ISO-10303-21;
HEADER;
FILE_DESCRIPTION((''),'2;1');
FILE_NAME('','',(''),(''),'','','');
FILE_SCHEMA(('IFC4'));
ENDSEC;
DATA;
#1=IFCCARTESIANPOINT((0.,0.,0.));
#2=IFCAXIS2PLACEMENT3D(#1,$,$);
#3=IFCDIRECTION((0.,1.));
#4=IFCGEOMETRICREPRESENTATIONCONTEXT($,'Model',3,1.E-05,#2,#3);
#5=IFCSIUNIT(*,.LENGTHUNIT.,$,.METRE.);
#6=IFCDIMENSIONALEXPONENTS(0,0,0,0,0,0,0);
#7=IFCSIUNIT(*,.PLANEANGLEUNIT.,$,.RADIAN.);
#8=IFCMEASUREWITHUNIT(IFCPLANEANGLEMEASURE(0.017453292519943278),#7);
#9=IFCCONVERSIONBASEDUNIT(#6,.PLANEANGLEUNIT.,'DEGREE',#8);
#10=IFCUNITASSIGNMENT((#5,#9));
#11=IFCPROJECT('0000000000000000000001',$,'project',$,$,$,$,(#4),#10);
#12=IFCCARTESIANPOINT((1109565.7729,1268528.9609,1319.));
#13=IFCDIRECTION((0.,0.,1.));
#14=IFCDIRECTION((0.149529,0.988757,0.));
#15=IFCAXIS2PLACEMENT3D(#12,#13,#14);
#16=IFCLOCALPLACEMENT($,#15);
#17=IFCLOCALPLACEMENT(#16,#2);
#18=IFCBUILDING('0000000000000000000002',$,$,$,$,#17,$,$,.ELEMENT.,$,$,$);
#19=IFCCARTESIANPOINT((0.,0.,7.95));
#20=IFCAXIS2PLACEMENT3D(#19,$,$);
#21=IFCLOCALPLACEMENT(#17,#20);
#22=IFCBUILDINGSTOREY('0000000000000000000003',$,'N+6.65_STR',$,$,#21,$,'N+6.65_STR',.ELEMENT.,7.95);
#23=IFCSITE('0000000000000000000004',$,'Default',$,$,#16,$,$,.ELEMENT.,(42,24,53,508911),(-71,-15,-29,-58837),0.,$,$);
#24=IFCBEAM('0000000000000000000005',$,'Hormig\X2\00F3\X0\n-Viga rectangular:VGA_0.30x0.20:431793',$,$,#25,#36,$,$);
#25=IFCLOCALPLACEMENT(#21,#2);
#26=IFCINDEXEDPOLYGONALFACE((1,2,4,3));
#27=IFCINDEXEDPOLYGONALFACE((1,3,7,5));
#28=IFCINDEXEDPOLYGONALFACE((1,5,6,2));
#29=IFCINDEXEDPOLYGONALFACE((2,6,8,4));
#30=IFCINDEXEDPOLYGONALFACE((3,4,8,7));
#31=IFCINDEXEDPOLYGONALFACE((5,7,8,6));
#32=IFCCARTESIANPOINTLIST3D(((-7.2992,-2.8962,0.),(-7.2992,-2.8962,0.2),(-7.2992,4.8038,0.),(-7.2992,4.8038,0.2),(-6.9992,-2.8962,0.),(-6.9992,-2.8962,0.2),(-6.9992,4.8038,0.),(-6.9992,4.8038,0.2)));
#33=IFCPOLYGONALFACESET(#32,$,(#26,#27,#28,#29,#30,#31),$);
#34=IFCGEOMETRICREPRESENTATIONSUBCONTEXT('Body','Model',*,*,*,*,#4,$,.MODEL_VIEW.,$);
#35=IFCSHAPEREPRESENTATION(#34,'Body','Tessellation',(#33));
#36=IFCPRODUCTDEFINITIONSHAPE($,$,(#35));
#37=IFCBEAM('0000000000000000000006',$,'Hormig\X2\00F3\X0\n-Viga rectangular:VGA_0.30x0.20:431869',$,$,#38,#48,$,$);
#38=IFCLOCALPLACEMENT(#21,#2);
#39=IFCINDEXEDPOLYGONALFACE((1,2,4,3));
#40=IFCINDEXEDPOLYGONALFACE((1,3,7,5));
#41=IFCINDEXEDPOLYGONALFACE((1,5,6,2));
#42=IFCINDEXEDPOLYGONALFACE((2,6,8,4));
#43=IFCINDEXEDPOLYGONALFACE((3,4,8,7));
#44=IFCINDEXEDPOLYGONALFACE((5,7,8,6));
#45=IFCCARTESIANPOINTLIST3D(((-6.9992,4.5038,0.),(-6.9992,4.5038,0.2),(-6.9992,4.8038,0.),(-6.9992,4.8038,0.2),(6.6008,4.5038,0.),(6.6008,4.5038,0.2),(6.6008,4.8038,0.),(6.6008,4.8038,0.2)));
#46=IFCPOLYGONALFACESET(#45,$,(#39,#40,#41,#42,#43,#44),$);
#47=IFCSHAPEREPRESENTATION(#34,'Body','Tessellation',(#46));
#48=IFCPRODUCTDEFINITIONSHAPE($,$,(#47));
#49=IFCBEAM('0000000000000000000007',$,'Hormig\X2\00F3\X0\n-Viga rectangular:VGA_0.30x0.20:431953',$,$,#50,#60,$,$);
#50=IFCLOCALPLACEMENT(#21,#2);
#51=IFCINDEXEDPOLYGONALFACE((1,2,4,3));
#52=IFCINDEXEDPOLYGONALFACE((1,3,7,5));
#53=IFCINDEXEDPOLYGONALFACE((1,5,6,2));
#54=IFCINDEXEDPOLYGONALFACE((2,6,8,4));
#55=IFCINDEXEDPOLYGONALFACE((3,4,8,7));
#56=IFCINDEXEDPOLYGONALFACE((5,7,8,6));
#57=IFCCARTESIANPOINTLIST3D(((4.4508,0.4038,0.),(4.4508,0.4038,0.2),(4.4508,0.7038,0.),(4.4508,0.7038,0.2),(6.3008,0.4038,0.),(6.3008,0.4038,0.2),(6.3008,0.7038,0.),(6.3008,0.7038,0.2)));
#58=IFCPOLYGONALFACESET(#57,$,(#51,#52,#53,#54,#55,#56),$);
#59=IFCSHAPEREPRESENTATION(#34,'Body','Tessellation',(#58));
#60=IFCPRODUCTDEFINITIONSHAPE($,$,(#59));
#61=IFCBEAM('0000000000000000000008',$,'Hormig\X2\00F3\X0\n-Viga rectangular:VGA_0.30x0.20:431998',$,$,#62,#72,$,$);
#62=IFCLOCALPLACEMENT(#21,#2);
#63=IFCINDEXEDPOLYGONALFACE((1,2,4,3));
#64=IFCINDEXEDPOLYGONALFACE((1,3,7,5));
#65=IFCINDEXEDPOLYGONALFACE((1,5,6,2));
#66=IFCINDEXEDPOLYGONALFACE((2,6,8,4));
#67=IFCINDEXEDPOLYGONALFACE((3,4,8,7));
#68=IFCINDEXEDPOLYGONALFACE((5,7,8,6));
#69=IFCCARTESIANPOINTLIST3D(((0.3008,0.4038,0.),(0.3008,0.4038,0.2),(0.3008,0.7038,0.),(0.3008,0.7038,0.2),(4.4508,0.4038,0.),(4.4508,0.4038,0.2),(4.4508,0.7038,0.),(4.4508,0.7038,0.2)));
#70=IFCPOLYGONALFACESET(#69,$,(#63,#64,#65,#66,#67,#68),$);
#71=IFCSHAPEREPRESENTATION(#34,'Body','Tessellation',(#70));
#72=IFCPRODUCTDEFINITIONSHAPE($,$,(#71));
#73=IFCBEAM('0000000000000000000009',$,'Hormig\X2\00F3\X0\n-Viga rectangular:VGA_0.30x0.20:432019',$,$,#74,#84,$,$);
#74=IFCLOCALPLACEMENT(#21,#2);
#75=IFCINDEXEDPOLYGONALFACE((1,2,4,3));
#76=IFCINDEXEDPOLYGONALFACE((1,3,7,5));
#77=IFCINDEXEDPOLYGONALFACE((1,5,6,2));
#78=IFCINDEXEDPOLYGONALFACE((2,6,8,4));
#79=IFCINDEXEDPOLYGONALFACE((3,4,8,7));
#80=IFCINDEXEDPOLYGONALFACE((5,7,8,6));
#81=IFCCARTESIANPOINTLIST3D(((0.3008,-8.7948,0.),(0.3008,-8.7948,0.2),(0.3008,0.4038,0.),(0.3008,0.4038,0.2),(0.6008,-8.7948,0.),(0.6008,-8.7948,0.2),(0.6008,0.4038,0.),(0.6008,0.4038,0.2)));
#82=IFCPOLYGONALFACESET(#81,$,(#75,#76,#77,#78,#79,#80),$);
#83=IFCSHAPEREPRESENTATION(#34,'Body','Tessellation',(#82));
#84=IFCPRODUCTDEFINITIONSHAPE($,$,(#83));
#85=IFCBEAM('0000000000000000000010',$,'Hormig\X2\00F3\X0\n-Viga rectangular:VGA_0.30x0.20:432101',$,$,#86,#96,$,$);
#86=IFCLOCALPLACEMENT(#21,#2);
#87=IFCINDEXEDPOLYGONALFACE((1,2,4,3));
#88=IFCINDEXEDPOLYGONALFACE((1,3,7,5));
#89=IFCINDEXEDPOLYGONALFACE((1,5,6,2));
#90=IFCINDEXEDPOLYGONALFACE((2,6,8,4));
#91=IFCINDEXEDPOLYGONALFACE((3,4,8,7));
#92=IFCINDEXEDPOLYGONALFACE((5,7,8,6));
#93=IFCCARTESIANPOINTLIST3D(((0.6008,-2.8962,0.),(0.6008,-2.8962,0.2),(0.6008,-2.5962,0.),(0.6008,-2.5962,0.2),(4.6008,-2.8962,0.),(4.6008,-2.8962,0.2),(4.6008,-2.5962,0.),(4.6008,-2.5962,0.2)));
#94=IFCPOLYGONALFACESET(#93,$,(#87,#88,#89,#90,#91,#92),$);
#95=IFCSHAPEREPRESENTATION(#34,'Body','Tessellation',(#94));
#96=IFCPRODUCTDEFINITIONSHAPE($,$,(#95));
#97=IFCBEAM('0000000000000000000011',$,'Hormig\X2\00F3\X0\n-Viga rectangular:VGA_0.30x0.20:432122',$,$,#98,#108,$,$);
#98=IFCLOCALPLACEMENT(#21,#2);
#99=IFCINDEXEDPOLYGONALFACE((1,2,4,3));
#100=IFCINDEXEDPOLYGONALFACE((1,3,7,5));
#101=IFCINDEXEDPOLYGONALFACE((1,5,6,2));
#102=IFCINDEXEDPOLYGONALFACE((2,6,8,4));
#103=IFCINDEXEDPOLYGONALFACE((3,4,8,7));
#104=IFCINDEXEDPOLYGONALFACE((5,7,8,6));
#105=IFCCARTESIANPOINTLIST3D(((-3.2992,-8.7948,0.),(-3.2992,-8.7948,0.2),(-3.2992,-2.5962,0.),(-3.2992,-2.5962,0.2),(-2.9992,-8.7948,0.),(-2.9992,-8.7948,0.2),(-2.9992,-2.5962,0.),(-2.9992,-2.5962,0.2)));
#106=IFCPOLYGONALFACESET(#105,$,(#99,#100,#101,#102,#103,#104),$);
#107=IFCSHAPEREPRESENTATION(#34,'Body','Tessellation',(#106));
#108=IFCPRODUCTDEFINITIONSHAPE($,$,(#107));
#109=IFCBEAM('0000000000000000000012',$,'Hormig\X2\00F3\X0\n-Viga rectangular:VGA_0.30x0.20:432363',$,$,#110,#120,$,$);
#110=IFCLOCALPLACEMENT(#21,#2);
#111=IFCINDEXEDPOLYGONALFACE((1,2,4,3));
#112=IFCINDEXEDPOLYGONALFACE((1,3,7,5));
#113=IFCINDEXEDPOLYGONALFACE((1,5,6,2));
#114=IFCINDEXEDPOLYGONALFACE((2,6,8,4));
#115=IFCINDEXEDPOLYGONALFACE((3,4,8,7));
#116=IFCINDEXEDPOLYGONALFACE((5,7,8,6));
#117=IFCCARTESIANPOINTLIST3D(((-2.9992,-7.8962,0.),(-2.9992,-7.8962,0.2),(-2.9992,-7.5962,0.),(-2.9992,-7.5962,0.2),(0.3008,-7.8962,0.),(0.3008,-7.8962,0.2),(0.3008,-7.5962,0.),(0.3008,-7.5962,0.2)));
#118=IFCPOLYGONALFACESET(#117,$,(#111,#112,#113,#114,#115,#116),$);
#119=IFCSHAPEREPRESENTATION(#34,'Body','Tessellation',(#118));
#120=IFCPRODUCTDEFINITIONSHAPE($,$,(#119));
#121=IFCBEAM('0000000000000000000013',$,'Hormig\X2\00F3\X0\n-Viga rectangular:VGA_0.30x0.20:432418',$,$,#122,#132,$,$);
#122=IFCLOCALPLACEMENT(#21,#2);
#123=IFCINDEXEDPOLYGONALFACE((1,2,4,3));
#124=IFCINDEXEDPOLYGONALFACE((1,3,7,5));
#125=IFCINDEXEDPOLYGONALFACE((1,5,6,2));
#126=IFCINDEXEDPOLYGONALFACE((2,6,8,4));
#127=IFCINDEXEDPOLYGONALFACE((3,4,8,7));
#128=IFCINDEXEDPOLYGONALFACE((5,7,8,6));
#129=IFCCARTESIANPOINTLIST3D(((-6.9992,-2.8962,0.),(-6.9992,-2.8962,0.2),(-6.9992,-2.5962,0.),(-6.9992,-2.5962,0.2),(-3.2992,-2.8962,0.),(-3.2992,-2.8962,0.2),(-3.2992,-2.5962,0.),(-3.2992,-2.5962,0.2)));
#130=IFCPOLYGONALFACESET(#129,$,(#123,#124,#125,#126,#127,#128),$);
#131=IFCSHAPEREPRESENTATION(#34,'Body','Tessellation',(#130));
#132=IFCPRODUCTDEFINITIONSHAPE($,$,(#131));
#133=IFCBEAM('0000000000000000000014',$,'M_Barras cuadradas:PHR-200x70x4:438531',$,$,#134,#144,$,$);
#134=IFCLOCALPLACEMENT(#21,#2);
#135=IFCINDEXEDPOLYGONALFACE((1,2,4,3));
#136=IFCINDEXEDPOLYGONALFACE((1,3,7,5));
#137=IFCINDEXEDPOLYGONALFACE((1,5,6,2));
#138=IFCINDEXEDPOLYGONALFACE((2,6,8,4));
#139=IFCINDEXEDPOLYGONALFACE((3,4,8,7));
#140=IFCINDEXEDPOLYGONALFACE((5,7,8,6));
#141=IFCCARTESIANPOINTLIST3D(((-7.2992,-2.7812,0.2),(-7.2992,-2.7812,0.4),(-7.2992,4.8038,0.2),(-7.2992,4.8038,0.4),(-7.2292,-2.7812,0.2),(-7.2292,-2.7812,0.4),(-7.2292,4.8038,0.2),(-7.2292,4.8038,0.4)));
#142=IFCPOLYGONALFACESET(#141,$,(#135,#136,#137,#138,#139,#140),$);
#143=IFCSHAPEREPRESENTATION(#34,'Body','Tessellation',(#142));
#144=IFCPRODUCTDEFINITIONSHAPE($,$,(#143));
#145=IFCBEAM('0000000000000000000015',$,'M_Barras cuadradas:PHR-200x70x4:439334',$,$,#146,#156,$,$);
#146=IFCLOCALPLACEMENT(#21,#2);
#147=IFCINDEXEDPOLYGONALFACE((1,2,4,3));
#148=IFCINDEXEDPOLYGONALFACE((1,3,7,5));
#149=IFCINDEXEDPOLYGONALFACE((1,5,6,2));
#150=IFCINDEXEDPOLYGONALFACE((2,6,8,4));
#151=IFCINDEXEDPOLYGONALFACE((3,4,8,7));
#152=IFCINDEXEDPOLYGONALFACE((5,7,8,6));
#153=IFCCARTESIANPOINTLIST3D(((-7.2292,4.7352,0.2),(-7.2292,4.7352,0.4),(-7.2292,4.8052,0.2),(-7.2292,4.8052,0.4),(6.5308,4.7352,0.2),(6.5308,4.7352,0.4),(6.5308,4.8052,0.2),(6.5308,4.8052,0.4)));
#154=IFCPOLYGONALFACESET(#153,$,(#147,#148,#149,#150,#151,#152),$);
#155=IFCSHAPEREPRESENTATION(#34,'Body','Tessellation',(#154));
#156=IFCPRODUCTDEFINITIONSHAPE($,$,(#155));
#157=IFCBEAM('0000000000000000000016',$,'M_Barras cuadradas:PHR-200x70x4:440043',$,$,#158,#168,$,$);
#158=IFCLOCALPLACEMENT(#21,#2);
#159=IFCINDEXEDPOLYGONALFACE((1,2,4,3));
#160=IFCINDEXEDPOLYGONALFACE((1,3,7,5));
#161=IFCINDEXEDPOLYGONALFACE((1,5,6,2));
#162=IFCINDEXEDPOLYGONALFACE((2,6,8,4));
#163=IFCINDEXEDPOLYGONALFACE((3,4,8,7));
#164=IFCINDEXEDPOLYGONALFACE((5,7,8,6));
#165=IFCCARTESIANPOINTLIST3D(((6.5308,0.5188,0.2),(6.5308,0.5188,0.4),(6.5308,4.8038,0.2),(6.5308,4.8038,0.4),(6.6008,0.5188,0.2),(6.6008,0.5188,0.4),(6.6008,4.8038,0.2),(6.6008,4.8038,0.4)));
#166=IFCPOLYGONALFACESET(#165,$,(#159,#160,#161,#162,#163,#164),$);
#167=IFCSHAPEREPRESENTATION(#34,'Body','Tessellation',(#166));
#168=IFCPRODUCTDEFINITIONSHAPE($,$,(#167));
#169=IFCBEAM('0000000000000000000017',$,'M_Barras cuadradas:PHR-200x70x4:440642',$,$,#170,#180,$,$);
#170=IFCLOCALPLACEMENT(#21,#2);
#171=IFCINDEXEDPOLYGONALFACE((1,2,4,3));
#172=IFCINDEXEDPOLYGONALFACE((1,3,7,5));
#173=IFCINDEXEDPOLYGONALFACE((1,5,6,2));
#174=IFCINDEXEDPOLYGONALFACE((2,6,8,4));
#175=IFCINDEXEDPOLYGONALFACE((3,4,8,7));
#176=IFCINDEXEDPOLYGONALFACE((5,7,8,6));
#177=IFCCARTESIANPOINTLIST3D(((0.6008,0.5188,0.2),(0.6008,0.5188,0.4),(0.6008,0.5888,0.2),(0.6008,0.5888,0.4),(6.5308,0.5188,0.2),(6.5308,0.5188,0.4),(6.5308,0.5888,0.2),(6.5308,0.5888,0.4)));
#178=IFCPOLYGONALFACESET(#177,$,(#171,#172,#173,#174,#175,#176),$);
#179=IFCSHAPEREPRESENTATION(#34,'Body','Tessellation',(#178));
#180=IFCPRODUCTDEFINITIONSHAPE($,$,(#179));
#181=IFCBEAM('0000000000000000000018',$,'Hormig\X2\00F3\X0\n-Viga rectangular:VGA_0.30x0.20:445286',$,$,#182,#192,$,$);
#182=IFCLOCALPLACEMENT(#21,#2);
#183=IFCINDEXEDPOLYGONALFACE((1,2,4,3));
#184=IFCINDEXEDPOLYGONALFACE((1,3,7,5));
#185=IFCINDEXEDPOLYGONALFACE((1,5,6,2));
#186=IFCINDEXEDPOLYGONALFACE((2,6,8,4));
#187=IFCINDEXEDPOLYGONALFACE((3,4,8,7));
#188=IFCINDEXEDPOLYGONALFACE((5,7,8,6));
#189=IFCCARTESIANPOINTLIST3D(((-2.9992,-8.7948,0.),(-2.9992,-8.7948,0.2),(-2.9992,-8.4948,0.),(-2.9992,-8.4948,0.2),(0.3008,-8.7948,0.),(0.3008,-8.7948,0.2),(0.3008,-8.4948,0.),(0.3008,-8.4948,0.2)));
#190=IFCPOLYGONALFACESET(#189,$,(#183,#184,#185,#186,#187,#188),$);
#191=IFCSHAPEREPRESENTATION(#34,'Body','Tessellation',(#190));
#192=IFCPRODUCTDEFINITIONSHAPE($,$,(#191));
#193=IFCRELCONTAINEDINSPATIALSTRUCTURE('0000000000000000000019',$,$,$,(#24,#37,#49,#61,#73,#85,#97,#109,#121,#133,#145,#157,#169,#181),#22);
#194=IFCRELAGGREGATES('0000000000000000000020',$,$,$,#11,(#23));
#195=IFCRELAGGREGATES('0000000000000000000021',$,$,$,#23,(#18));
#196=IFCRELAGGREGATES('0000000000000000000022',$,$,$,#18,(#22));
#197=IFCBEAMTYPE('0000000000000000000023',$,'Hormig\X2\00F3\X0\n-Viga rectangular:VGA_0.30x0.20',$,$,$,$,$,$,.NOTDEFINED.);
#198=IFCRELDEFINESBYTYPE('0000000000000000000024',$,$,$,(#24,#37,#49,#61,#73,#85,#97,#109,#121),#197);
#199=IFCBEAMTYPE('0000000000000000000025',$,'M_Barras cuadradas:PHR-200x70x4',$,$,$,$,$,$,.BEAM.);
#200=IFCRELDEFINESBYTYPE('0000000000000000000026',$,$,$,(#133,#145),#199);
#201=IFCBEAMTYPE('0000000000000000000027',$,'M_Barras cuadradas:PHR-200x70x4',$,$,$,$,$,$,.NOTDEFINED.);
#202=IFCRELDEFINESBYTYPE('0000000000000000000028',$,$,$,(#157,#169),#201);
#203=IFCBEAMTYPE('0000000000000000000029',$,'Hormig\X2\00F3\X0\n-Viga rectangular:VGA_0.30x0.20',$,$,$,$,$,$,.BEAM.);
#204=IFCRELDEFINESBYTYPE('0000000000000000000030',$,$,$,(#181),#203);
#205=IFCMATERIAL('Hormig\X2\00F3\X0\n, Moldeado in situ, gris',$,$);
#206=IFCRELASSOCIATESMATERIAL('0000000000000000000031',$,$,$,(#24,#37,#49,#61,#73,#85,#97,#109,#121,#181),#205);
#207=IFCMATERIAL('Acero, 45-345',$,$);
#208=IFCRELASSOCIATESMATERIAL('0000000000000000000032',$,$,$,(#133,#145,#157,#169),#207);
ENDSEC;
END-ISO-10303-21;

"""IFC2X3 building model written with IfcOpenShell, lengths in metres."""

from ifc_helpers import new_model, entity, si_unit, converted_unit, direction, frame, frame_2d, origin, place, context, subcontext, project, spatial, rectangle, extrude, material, type_object, element, save


model = new_model("IFC2X3")

# Units and contexts
model_context = context("Model", 3, precision=1e-05, world=origin(), true_north=direction((0.0, 1.0)))
body_context = subcontext(model_context, "Body", "Model", "MODEL_VIEW")
ifc_project = project(units=[si_unit("LENGTHUNIT", "METRE"), converted_unit("PLANEANGLEUNIT", "DEGREE", entity("IfcPlaneAngleMeasure", 0.017453292519943278), si_unit("PLANEANGLEUNIT", "RADIAN"), dimensions=[0, 0, 0, 0, 0, 0, 0])], contexts=[model_context])

# Site, building, storey
site_placement = place(None, frame((1109565.7729, 1268528.9609, 1319.0), z_axis=(0.0, 0.0, 1.0), x_axis=(0.149529, 0.988757, 0.0)))
site = spatial("IfcSite", under=ifc_project, at=site_placement, Name="Default", CompositionType="ELEMENT", RefLatitude=(42, 24, 53, 508911), RefLongitude=(-71, -15, -29, -58837), RefElevation=0.0)
building_placement = place(site_placement, origin())
building = spatial("IfcBuilding", under=site, at=building_placement, CompositionType="ELEMENT")
storey_placement = place(building_placement, frame((0.0, 0.0, 7.95)))
storey = spatial("IfcBuildingStorey", under=building, at=storey_placement, Name="N+6.65_STR", LongName="N+6.65_STR", CompositionType="ELEMENT", Elevation=7.95)

# Beams
ifc_material_1 = material(Name="Hormigón, Moldeado in situ, gris")
beam_type_1 = type_object("IfcBeamType", Name="Hormigón-Viga rectangular:VGA_0.30x0.20", PredefinedType="NOTDEFINED")
beam_1_placement = place(storey_placement, frame((-7.1492, -2.7462, 0.0), z_axis=(0.0, 0.0, 1.0), x_axis=(0.0, 1.0, 0.0)))
element("IfcBeam", 1, at=beam_1_placement, inside=storey, type_object=beam_type_1, material=ifc_material_1, Name="Hormigón-Viga rectangular:VGA_0.30x0.20:431793", context=body_context, shape_type="SweptSolid", body=[
    extrude(rectangle(XDim=0.2, YDim=0.3, at=frame_2d((0.0, 0.0), x_axis=(1.0, 0.0))), frame((-0.15, 0.0, 0.1), z_axis=(1.0, 0.0, 0.0), x_axis=(0.0, 0.0, -1.0)), (0.0, 0.0, 1.0), 7.7),
])
beam_2_placement = place(storey_placement, frame((-7.1492, 4.6538, 0.0)))
element("IfcBeam", 2, at=beam_2_placement, inside=storey, type_object=beam_type_1, material=ifc_material_1, Name="Hormigón-Viga rectangular:VGA_0.30x0.20:431869", context=body_context, shape_type="SweptSolid", body=[
    extrude(rectangle(XDim=0.2, YDim=0.3, at=frame_2d((0.0, 0.0), x_axis=(1.0, 0.0))), frame((0.15, 0.0, 0.1), z_axis=(1.0, 0.0, 0.0), x_axis=(0.0, 0.0, -1.0)), (0.0, 0.0, 1.0), 13.6),
])
beam_3_placement = place(storey_placement, frame((6.4508, 0.5538, 0.0), z_axis=(0.0, 0.0, 1.0), x_axis=(-1.0, 0.0, 0.0)))
element("IfcBeam", 3, at=beam_3_placement, inside=storey, type_object=beam_type_1, material=ifc_material_1, Name="Hormigón-Viga rectangular:VGA_0.30x0.20:431953", context=body_context, shape_type="SweptSolid", body=[
    extrude(rectangle(XDim=0.2, YDim=0.3, at=frame_2d((0.0, 0.0), x_axis=(1.0, 0.0))), frame((0.15, 0.0, 0.1), z_axis=(1.0, 0.0, 0.0), x_axis=(0.0, 0.0, -1.0)), (0.0, 0.0, 1.0), 1.85),
])
beam_4_placement = place(storey_placement, frame((4.4508, 0.5538, 0.0), z_axis=(0.0, 0.0, 1.0), x_axis=(-1.0, 0.0, 0.0)))
element("IfcBeam", 4, at=beam_4_placement, inside=storey, type_object=beam_type_1, material=ifc_material_1, Name="Hormigón-Viga rectangular:VGA_0.30x0.20:431998", context=body_context, shape_type="SweptSolid", body=[
    extrude(rectangle(XDim=0.2, YDim=0.3, at=frame_2d((0.0, 0.0), x_axis=(1.0, 0.0))), frame((0.0, 0.0, 0.1), z_axis=(1.0, 0.0, 0.0), x_axis=(0.0, 0.0, -1.0)), (0.0, 0.0, 1.0), 4.15),
])
beam_5_placement = place(storey_placement, frame((0.4508, 0.5538, 0.0), z_axis=(0.0, 0.0, 1.0), x_axis=(0.0, -1.0, 0.0)))
element("IfcBeam", 5, at=beam_5_placement, inside=storey, type_object=beam_type_1, material=ifc_material_1, Name="Hormigón-Viga rectangular:VGA_0.30x0.20:432019", context=body_context, shape_type="SweptSolid", body=[
    extrude(rectangle(XDim=0.2, YDim=0.3, at=frame_2d((0.0, 0.0), x_axis=(1.0, 0.0))), frame((0.15, 0.0, 0.1), z_axis=(1.0, 0.0, 0.0), x_axis=(0.0, 0.0, -1.0)), (0.0, 0.0, 1.0), 9.1986),
])
beam_6_placement = place(storey_placement, frame((4.6008, -2.7462, 0.0), z_axis=(0.0, 0.0, 1.0), x_axis=(-1.0, 0.0, 0.0)))
element("IfcBeam", 6, at=beam_6_placement, inside=storey, type_object=beam_type_1, material=ifc_material_1, Name="Hormigón-Viga rectangular:VGA_0.30x0.20:432101", context=body_context, shape_type="SweptSolid", body=[
    extrude(rectangle(XDim=0.2, YDim=0.3, at=frame_2d((0.0, 0.0), x_axis=(1.0, 0.0))), frame((0.0, 0.0, 0.1), z_axis=(1.0, 0.0, 0.0), x_axis=(0.0, 0.0, -1.0)), (0.0, 0.0, 1.0), 4.0),
])
beam_7_placement = place(storey_placement, frame((-3.1492, -2.7462, 0.0), z_axis=(0.0, 0.0, 1.0), x_axis=(0.0, -1.0, 0.0)))
element("IfcBeam", 7, at=beam_7_placement, inside=storey, type_object=beam_type_1, material=ifc_material_1, Name="Hormigón-Viga rectangular:VGA_0.30x0.20:432122", context=body_context, shape_type="SweptSolid", body=[
    extrude(rectangle(XDim=0.2, YDim=0.3, at=frame_2d((0.0, 0.0), x_axis=(1.0, 0.0))), frame((-0.15, 0.0, 0.1), z_axis=(1.0, 0.0, 0.0), x_axis=(0.0, 0.0, -1.0)), (0.0, 0.0, 1.0), 6.1986),
])
beam_8_placement = place(storey_placement, frame((-3.1492, -7.7462, 0.0)))
element("IfcBeam", 8, at=beam_8_placement, inside=storey, type_object=beam_type_1, material=ifc_material_1, Name="Hormigón-Viga rectangular:VGA_0.30x0.20:432363", context=body_context, shape_type="SweptSolid", body=[
    extrude(rectangle(XDim=0.2, YDim=0.3, at=frame_2d((0.0, 0.0), x_axis=(1.0, 0.0))), frame((0.15, 0.0, 0.1), z_axis=(1.0, 0.0, 0.0), x_axis=(0.0, 0.0, -1.0)), (0.0, 0.0, 1.0), 3.3),
])
beam_9_placement = place(storey_placement, frame((-7.1492, -2.7462, 0.0)))
element("IfcBeam", 9, at=beam_9_placement, inside=storey, type_object=beam_type_1, material=ifc_material_1, Name="Hormigón-Viga rectangular:VGA_0.30x0.20:432418", context=body_context, shape_type="SweptSolid", body=[
    extrude(rectangle(XDim=0.2, YDim=0.3, at=frame_2d((0.0, 0.0), x_axis=(1.0, 0.0))), frame((0.15, 0.0, 0.1), z_axis=(1.0, 0.0, 0.0), x_axis=(0.0, 0.0, -1.0)), (0.0, 0.0, 1.0), 3.7),
])
ifc_material_2 = material(Name="Acero, 45-345")
beam_type_2 = type_object("IfcBeamType", Name="M_Barras cuadradas:PHR-200x70x4", PredefinedType="BEAM")
beam_10_placement = place(storey_placement, frame((-7.2642, 4.7702, 0.2), z_axis=(0.0, 0.0, 1.0), x_axis=(0.0, -1.0, 0.0)))
element("IfcBeam", 10, at=beam_10_placement, inside=storey, type_object=beam_type_2, material=ifc_material_2, Name="M_Barras cuadradas:PHR-200x70x4:438531", context=body_context, shape_type="SweptSolid", body=[
    extrude(rectangle(XDim=0.2, YDim=0.07, at=frame_2d((0.0, 0.0), x_axis=(1.0, 0.0))), frame((-0.0336, 0.0, 0.1), z_axis=(1.0, 0.0, 0.0), x_axis=(0.0, 0.0, -1.0)), (0.0, 0.0, 1.0), 7.585),
])
beam_11_placement = place(storey_placement, frame((-7.2642, 4.7702, 0.2)))
element("IfcBeam", 11, at=beam_11_placement, inside=storey, type_object=beam_type_2, material=ifc_material_2, Name="M_Barras cuadradas:PHR-200x70x4:439334", context=body_context, shape_type="SweptSolid", body=[
    extrude(rectangle(XDim=0.2, YDim=0.07, at=frame_2d((0.0, 0.0), x_axis=(1.0, 0.0))), frame((0.035, 0.0, 0.1), z_axis=(1.0, 0.0, 0.0), x_axis=(0.0, 0.0, -1.0)), (0.0, 0.0, 1.0), 13.76),
])
beam_type_3 = type_object("IfcBeamType", Name="M_Barras cuadradas:PHR-200x70x4", PredefinedType="NOTDEFINED")
beam_12_placement = place(storey_placement, frame((6.5658, 4.7702, 0.2), z_axis=(0.0, 0.0, 1.0), x_axis=(0.0, -1.0, 0.0)))
element("IfcBeam", 12, at=beam_12_placement, inside=storey, type_object=beam_type_3, material=ifc_material_2, Name="M_Barras cuadradas:PHR-200x70x4:440043", context=body_context, shape_type="SweptSolid", body=[
    extrude(rectangle(XDim=0.2, YDim=0.07, at=frame_2d((0.0, 0.0), x_axis=(1.0, 0.0))), frame((-0.0336, 0.0, 0.1), z_axis=(1.0, 0.0, 0.0), x_axis=(0.0, 0.0, -1.0)), (0.0, 0.0, 1.0), 4.285),
])
beam_13_placement = place(storey_placement, frame((6.5058, 0.5538, 0.2), z_axis=(0.0, 0.0, 1.0), x_axis=(-1.0, 0.0, 0.0)))
element("IfcBeam", 13, at=beam_13_placement, inside=storey, type_object=beam_type_3, material=ifc_material_2, Name="M_Barras cuadradas:PHR-200x70x4:440642", context=body_context, shape_type="SweptSolid", body=[
    extrude(rectangle(XDim=0.2, YDim=0.07, at=frame_2d((0.0, 0.0), x_axis=(1.0, 0.0))), frame((-0.025, 0.0, 0.1), z_axis=(1.0, 0.0, 0.0), x_axis=(0.0, 0.0, -1.0)), (0.0, 0.0, 1.0), 5.93),
])
beam_type_4 = type_object("IfcBeamType", Name="Hormigón-Viga rectangular:VGA_0.30x0.20", PredefinedType="BEAM")
beam_14_placement = place(storey_placement, frame((-3.1492, -8.6448, 0.0)))
element("IfcBeam", 14, at=beam_14_placement, inside=storey, type_object=beam_type_4, material=ifc_material_1, Name="Hormigón-Viga rectangular:VGA_0.30x0.20:445286", context=body_context, shape_type="SweptSolid", body=[
    extrude(rectangle(XDim=0.2, YDim=0.3, at=frame_2d((0.0, 0.0), x_axis=(1.0, 0.0))), frame((0.15, 0.0, 0.1), z_axis=(1.0, 0.0, 0.0), x_axis=(0.0, 0.0, -1.0)), (0.0, 0.0, 1.0), 3.3),
])

save(model, "model.ifc")
